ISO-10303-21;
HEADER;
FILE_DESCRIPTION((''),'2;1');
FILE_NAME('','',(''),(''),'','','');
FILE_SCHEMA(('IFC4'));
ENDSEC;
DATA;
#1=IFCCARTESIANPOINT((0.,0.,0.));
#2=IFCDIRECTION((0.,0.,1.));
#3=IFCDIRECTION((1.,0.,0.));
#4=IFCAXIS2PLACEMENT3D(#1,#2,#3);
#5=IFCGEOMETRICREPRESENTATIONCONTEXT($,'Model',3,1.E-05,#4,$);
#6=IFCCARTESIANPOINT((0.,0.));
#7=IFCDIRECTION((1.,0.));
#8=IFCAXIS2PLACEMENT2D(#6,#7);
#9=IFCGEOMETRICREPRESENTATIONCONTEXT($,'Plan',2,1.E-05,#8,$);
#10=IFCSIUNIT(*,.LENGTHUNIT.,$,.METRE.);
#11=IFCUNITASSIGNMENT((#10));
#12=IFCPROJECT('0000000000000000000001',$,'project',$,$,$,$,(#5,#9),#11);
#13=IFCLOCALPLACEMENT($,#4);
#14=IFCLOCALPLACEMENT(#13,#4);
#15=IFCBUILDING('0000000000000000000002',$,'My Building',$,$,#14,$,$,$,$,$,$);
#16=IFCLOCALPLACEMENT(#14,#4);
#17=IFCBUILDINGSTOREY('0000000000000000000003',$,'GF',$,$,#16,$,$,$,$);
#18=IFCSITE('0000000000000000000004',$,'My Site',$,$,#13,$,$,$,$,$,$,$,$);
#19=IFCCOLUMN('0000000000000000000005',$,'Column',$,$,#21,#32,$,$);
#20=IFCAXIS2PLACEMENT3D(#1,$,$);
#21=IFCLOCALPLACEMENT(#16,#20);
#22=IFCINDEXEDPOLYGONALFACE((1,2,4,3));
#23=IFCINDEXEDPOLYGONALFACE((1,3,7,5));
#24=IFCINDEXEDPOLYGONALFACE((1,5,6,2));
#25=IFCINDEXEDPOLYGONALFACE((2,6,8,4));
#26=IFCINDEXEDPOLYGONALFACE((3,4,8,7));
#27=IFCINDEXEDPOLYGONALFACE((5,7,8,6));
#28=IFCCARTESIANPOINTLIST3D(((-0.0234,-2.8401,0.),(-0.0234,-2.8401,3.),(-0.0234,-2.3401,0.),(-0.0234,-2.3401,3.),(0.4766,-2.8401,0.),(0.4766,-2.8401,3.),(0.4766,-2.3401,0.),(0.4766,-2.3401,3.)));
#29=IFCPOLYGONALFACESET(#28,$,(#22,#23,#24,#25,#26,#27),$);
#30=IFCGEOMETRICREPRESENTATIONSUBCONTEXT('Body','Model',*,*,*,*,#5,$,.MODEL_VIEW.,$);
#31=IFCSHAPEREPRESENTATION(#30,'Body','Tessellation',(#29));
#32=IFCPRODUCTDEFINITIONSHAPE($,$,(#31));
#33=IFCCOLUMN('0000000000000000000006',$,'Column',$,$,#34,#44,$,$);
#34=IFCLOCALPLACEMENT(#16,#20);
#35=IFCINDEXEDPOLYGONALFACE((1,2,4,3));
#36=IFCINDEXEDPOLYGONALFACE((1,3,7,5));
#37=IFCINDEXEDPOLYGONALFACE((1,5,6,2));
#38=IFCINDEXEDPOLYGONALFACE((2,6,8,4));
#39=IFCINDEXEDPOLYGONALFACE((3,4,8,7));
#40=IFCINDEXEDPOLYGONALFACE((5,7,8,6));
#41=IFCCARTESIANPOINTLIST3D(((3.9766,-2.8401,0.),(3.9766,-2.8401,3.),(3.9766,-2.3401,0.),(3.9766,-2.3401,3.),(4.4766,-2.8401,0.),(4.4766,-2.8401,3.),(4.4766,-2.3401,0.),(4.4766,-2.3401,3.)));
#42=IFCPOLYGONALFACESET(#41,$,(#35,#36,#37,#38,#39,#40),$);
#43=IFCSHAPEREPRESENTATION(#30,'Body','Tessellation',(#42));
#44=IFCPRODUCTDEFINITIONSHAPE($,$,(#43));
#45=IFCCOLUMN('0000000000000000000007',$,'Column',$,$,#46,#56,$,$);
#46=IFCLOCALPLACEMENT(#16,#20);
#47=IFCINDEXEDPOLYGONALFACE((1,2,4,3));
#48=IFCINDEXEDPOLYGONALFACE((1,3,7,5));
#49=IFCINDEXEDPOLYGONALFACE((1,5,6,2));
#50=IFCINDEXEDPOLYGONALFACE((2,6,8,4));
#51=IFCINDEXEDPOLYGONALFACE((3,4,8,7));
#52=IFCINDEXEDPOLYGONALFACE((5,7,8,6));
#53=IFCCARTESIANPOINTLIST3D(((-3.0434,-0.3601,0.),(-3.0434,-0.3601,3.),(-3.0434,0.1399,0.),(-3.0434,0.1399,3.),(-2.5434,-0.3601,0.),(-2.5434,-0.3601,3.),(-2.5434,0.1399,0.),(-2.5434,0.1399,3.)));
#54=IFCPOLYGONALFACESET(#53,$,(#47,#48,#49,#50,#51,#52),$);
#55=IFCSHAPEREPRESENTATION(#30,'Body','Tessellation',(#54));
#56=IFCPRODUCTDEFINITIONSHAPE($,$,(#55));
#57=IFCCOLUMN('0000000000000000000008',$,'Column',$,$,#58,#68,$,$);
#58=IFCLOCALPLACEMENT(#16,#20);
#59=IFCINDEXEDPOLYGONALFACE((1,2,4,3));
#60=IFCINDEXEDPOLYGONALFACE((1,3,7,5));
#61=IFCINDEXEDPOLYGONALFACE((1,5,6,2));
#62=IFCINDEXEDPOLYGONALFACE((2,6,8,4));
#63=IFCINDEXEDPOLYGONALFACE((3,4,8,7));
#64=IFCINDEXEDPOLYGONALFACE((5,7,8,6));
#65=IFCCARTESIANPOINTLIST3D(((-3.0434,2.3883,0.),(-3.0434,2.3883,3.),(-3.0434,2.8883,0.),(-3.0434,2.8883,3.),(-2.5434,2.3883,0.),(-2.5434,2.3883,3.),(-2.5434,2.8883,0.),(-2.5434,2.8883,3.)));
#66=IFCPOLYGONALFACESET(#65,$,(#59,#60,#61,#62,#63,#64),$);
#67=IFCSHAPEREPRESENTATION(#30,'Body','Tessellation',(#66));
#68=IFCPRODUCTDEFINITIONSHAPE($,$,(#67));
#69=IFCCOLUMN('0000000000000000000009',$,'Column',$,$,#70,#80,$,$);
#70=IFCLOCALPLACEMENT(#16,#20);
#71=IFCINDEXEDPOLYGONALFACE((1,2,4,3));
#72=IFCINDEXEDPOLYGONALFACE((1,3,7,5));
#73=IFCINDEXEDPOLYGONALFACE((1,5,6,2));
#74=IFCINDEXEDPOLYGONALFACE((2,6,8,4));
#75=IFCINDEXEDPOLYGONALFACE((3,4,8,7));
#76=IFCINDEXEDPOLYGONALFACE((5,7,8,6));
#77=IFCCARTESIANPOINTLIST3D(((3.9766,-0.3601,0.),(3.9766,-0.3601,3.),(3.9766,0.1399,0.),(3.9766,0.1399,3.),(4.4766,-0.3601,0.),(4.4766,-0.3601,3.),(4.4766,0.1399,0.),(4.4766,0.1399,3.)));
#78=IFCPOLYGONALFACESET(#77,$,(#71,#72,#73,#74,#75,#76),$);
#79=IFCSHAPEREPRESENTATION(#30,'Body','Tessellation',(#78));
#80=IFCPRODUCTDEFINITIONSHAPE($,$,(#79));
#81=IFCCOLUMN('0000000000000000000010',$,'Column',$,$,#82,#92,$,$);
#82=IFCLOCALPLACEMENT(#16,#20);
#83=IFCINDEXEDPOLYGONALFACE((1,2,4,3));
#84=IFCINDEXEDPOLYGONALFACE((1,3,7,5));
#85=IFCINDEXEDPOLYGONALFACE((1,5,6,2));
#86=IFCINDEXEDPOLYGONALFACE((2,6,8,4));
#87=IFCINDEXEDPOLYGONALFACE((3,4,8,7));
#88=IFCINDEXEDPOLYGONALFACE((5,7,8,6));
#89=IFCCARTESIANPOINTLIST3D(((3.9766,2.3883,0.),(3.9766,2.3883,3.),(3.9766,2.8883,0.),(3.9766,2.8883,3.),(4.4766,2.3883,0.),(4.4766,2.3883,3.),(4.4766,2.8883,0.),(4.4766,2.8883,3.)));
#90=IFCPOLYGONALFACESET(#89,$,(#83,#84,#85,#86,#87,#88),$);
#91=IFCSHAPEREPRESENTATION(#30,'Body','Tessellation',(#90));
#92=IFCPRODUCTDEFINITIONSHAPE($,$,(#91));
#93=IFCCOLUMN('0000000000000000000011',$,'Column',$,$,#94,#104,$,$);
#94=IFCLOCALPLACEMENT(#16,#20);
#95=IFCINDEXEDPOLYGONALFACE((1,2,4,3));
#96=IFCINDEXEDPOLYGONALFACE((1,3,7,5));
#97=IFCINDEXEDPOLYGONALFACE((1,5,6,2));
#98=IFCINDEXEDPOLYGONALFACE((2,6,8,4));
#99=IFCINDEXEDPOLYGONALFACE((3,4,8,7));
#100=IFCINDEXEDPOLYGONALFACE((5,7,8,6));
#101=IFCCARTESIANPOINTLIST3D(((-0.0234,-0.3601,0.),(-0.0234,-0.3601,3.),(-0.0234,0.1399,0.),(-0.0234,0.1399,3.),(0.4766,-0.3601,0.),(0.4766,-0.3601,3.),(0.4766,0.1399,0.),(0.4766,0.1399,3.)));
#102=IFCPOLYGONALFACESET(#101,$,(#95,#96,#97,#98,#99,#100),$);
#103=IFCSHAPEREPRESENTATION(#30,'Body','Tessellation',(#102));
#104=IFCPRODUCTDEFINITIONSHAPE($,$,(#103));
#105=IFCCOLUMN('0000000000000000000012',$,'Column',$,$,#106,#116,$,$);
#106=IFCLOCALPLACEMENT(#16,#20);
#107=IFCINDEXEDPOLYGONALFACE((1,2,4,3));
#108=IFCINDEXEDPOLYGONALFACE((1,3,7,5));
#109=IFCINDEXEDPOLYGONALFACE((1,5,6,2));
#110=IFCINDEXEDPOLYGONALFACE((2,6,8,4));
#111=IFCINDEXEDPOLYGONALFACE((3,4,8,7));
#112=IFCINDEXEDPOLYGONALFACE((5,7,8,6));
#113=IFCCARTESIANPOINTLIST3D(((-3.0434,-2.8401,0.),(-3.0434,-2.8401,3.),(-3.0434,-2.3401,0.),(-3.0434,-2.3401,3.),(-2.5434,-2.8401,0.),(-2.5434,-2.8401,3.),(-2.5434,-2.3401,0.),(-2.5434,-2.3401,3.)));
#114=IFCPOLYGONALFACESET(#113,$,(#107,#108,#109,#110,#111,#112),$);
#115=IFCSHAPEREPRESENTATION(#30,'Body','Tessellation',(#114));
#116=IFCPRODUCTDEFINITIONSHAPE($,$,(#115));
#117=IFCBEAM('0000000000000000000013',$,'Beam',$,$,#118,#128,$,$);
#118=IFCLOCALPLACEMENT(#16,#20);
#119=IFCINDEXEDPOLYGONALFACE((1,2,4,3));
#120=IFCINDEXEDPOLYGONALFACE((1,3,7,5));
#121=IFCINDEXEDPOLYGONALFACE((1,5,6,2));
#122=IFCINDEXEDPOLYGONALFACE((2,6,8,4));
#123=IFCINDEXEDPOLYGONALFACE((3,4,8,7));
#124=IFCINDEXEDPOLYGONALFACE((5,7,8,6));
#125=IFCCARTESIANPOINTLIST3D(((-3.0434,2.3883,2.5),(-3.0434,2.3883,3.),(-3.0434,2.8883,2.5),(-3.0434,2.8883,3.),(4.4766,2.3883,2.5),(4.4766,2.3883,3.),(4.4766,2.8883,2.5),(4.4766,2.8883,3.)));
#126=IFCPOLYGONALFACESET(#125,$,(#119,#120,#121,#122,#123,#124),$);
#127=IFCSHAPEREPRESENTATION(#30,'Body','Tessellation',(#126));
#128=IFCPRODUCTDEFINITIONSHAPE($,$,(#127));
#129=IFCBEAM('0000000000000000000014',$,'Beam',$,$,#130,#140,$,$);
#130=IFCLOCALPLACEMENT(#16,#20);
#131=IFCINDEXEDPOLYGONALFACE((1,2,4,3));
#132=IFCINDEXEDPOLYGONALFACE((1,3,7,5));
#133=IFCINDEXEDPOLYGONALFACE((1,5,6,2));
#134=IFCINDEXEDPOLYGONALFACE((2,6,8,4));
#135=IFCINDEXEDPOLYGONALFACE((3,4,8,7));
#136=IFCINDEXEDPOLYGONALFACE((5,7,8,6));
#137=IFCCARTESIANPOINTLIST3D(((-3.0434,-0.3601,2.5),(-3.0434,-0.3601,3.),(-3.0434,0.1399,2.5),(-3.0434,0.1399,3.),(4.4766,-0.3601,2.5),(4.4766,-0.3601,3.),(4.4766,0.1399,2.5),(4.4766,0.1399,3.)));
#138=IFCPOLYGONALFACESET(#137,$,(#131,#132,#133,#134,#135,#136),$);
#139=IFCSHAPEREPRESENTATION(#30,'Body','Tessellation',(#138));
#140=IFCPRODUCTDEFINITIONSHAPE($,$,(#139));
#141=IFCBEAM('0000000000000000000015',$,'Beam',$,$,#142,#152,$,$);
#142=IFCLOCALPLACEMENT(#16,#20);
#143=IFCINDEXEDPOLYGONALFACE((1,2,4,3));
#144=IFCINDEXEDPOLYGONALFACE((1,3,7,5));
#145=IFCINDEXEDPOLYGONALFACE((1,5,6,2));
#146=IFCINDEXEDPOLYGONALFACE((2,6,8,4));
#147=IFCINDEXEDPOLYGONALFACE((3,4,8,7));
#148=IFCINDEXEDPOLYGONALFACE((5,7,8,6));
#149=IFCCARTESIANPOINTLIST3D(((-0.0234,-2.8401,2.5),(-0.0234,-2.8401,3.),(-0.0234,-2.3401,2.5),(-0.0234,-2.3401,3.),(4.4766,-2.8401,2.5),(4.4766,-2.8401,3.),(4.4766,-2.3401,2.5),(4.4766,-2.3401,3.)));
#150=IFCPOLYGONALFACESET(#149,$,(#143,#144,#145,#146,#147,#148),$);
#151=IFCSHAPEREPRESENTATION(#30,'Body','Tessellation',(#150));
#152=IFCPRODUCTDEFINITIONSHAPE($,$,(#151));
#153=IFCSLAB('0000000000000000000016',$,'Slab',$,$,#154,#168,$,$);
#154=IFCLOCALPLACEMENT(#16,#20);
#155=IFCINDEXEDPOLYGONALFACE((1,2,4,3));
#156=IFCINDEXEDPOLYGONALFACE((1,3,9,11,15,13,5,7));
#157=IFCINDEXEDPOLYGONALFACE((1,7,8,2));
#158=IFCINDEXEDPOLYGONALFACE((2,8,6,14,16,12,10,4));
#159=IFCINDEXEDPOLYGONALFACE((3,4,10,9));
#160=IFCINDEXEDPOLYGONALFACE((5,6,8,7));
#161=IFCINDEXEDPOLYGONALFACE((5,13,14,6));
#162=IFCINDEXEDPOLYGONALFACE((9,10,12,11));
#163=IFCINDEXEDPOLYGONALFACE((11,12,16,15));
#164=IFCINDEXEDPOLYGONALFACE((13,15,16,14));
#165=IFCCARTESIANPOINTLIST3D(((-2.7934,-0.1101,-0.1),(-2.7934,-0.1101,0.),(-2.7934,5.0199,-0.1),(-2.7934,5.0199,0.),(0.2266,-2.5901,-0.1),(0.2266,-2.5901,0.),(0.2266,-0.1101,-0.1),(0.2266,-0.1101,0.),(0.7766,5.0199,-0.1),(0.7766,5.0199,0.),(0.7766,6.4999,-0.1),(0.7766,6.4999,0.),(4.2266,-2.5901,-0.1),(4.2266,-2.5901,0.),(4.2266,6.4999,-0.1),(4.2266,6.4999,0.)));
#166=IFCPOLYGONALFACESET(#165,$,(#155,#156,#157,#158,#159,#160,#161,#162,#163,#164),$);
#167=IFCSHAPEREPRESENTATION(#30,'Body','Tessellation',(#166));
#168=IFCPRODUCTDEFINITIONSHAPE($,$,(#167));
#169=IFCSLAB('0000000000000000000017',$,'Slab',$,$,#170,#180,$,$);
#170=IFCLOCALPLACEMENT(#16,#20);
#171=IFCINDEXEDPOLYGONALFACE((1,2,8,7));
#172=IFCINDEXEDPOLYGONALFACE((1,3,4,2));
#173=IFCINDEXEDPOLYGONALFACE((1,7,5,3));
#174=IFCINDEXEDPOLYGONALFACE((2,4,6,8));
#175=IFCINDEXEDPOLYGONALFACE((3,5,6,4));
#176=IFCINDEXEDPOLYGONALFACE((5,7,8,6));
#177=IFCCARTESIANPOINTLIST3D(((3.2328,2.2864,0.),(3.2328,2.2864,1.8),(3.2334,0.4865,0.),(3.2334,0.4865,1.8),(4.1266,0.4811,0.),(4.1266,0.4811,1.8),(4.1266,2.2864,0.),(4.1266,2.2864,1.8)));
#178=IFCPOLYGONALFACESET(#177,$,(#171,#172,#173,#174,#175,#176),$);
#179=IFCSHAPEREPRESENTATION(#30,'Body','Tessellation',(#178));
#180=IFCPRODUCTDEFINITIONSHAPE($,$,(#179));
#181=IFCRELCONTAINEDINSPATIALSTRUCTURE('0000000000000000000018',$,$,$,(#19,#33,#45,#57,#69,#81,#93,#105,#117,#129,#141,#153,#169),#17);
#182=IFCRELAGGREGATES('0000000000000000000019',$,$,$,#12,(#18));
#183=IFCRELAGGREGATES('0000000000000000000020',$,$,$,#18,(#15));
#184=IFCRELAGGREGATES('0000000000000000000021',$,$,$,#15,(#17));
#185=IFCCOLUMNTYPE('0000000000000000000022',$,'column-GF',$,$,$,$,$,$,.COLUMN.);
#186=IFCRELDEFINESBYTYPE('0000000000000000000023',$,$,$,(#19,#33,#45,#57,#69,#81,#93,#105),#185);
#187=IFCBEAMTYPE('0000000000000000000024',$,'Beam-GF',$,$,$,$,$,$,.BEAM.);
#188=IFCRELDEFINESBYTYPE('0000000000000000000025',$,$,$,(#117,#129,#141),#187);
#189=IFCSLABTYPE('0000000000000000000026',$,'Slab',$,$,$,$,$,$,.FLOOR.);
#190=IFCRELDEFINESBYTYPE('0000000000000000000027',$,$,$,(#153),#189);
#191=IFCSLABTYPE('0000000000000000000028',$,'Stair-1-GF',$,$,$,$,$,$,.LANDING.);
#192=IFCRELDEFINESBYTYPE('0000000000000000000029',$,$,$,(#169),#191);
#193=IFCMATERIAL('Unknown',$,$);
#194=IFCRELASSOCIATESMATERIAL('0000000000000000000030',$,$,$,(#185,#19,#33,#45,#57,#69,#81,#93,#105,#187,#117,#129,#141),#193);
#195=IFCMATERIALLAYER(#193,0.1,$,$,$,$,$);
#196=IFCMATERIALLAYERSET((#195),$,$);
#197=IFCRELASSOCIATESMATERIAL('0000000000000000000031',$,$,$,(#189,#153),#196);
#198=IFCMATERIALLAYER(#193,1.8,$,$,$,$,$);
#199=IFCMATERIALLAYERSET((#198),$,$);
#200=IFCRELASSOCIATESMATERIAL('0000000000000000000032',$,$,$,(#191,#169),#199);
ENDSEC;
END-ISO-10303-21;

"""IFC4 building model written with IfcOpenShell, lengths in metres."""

from ifc_helpers import new_model, si_unit, frame, origin_with_axes, origin_2d_with_axis, place, context, subcontext, project, spatial, indexed_curve, rectangle, outline, extrude, material, layer, layer_set, layer_usage, material_profile, profile_set, profile_usage, type_object, element, save


model = new_model("IFC4")

# Units and contexts
model_context = context("Model", 3, precision=1e-05, world=origin_with_axes())
plan_context = context("Plan", 2, precision=1e-05, world=origin_2d_with_axis())
body_context_1 = subcontext(model_context, "Body", "Model", "MODEL_VIEW")
ifc_project = project(units=[si_unit("LENGTHUNIT", "METRE")], contexts=[model_context, plan_context])

# Site, building, storey
site_placement = place(None, origin_with_axes())
site = spatial("IfcSite", under=ifc_project, at=site_placement, Name="My Site")
building_placement = place(site_placement, origin_with_axes())
building = spatial("IfcBuilding", under=site, at=building_placement, Name="My Building")
storey_placement = place(building_placement, origin_with_axes())
storey = spatial("IfcBuildingStorey", under=building, at=storey_placement, Name="GF")

# Columns
ifc_material = material(Name="Unknown")
ifc_material_profile_1 = material_profile(ifc_material, rectangle(XDim=0.5, YDim=0.5))
ifc_profile_set_1 = profile_set([ifc_material_profile_1])
ifc_profile_usage_1 = profile_usage(ifc_profile_set_1, cardinal=5)
column_type = type_object("IfcColumnType", Name="column-GF", PredefinedType="COLUMN", material=ifc_profile_set_1)
column_1_placement = place(storey_placement, frame((0.2266, -2.5901, 0.0), z_axis=(0.0, 0.0, 1.0), x_axis=(1.0, 0.0, 0.0)))
element("IfcColumn", 1, at=column_1_placement, inside=storey, type_object=column_type, material=ifc_profile_usage_1, Name="Column", context=body_context_1, shape_type="SweptSolid", body=[
    extrude(rectangle(XDim=0.5, YDim=0.5), origin_with_axes(), (0.0, 0.0, 1.0), 3.0),
])
ifc_profile_usage_2 = profile_usage(ifc_profile_set_1, cardinal=5)
column_2_placement = place(storey_placement, frame((4.2266, -2.5901, 0.0), z_axis=(0.0, 0.0, 1.0), x_axis=(1.0, 0.0, 0.0)))
element("IfcColumn", 2, at=column_2_placement, inside=storey, type_object=column_type, material=ifc_profile_usage_2, Name="Column", context=body_context_1, shape_type="SweptSolid", body=[
    extrude(rectangle(XDim=0.5, YDim=0.5), origin_with_axes(), (0.0, 0.0, 1.0), 3.0),
])
ifc_profile_usage_3 = profile_usage(ifc_profile_set_1, cardinal=5)
column_3_placement = place(storey_placement, frame((-2.7934, -0.1101, 0.0), z_axis=(0.0, 0.0, 1.0), x_axis=(1.0, 0.0, 0.0)))
element("IfcColumn", 3, at=column_3_placement, inside=storey, type_object=column_type, material=ifc_profile_usage_3, Name="Column", context=body_context_1, shape_type="SweptSolid", body=[
    extrude(rectangle(XDim=0.5, YDim=0.5), origin_with_axes(), (0.0, 0.0, 1.0), 3.0),
])
ifc_profile_usage_4 = profile_usage(ifc_profile_set_1, cardinal=5)
column_4_placement = place(storey_placement, frame((-2.7934, 2.6383, 0.0), z_axis=(0.0, 0.0, 1.0), x_axis=(1.0, 0.0, 0.0)))
element("IfcColumn", 4, at=column_4_placement, inside=storey, type_object=column_type, material=ifc_profile_usage_4, Name="Column", context=body_context_1, shape_type="SweptSolid", body=[
    extrude(rectangle(XDim=0.5, YDim=0.5), origin_with_axes(), (0.0, 0.0, 1.0), 3.0),
])
ifc_profile_usage_5 = profile_usage(ifc_profile_set_1, cardinal=5)
column_5_placement = place(storey_placement, frame((4.2266, -0.1101, 0.0), z_axis=(0.0, 0.0, 1.0), x_axis=(1.0, 0.0, 0.0)))
element("IfcColumn", 5, at=column_5_placement, inside=storey, type_object=column_type, material=ifc_profile_usage_5, Name="Column", context=body_context_1, shape_type="SweptSolid", body=[
    extrude(rectangle(XDim=0.5, YDim=0.5), origin_with_axes(), (0.0, 0.0, 1.0), 3.0),
])
ifc_profile_usage_6 = profile_usage(ifc_profile_set_1, cardinal=5)
column_6_placement = place(storey_placement, frame((4.2266, 2.6383, 0.0), z_axis=(0.0, 0.0, 1.0), x_axis=(1.0, 0.0, 0.0)))
element("IfcColumn", 6, at=column_6_placement, inside=storey, type_object=column_type, material=ifc_profile_usage_6, Name="Column", context=body_context_1, shape_type="SweptSolid", body=[
    extrude(rectangle(XDim=0.5, YDim=0.5), origin_with_axes(), (0.0, 0.0, 1.0), 3.0),
])
ifc_profile_usage_7 = profile_usage(ifc_profile_set_1, cardinal=5)
column_7_placement = place(storey_placement, frame((0.2266, -0.1101, 0.0), z_axis=(0.0, 0.0, 1.0), x_axis=(1.0, 0.0, 0.0)))
element("IfcColumn", 7, at=column_7_placement, inside=storey, type_object=column_type, material=ifc_profile_usage_7, Name="Column", context=body_context_1, shape_type="SweptSolid", body=[
    extrude(rectangle(XDim=0.5, YDim=0.5), origin_with_axes(), (0.0, 0.0, 1.0), 3.0),
])
ifc_profile_usage_8 = profile_usage(ifc_profile_set_1, cardinal=5)
column_8_placement = place(storey_placement, frame((-2.7934, -2.5901, 0.0), z_axis=(0.0, 0.0, 1.0), x_axis=(1.0, 0.0, 0.0)))
element("IfcColumn", 8, at=column_8_placement, inside=storey, type_object=column_type, material=ifc_profile_usage_8, Name="Column", context=body_context_1, shape_type="SweptSolid", body=[
    extrude(rectangle(XDim=0.5, YDim=0.5), origin_with_axes(), (0.0, 0.0, 1.0), 3.0),
])

# Beams
ifc_material_profile_2 = material_profile(ifc_material, rectangle(XDim=0.5, YDim=0.5))
ifc_profile_set_2 = profile_set([ifc_material_profile_2])
ifc_profile_usage_9 = profile_usage(ifc_profile_set_2, cardinal=7)
beam_type = type_object("IfcBeamType", Name="Beam-GF", PredefinedType="BEAM", material=ifc_profile_set_2)
beam_1_placement = place(storey_placement, frame((4.4766, 2.3883, 3.0), z_axis=(-1.0, 0.0, 0.0), x_axis=(0.0, -1.0, 0.0)))
element("IfcBeam", 9, at=beam_1_placement, inside=storey, type_object=beam_type, material=ifc_profile_usage_9, Name="Beam", context=body_context_1, shape_type="SweptSolid", body=[
    extrude(rectangle(XDim=0.5, YDim=0.5), frame((-0.25, -0.25, 0.0), z_axis=(0.0, 0.0, 1.0), x_axis=(1.0, 0.0, 0.0)), (0.0, 0.0, 1.0), 7.52),
])
ifc_profile_usage_10 = profile_usage(ifc_profile_set_2, cardinal=7)
beam_2_placement = place(storey_placement, frame((4.4766, -0.3601, 3.0), z_axis=(-1.0, 0.0, 0.0), x_axis=(0.0, -1.0, 0.0)))
element("IfcBeam", 10, at=beam_2_placement, inside=storey, type_object=beam_type, material=ifc_profile_usage_10, Name="Beam", context=body_context_1, shape_type="SweptSolid", body=[
    extrude(rectangle(XDim=0.5, YDim=0.5), frame((-0.25, -0.25, 0.0), z_axis=(0.0, 0.0, 1.0), x_axis=(1.0, 0.0, 0.0)), (0.0, 0.0, 1.0), 7.52),
])
ifc_profile_usage_11 = profile_usage(ifc_profile_set_2, cardinal=7)
beam_3_placement = place(storey_placement, frame((4.4766, -2.8401, 3.0), z_axis=(-1.0, -0.000001, 0.000001), x_axis=(0.000001, -1.0, 0.0)))
element("IfcBeam", 11, at=beam_3_placement, inside=storey, type_object=beam_type, material=ifc_profile_usage_11, Name="Beam", context=body_context_1, shape_type="SweptSolid", body=[
    extrude(rectangle(XDim=0.5, YDim=0.5), frame((-0.25, -0.25, 0.0), z_axis=(0.0, 0.0, 1.0), x_axis=(1.0, 0.0, 0.0)), (0.0, 0.0, 1.0), 4.5),
])

# Slabs
ifc_layer_1 = layer(ifc_material, 0.1)
ifc_layer_set_1 = layer_set([ifc_layer_1])
ifc_layer_usage_1 = layer_usage(ifc_layer_set_1, "AXIS3", "POSITIVE", -0.1)
slab_type_1 = type_object("IfcSlabType", Name="Slab", PredefinedType="FLOOR", material=ifc_layer_set_1)
slab_1_placement = place(storey_placement, frame((4.2266, -2.5901, 0.0), z_axis=(0.0, 0.0, 1.0), x_axis=(1.0, 0.0, 0.0)))
element("IfcSlab", 12, at=slab_1_placement, inside=storey, type_object=slab_type_1, material=ifc_layer_usage_1, Name="Slab", context=body_context_1, shape_type="SweptSolid", body=[
    extrude(outline(indexed_curve([(0.0, 0.0), (0.0, 9.09), (-3.45, 9.09), (-3.45, 7.61), (-7.02, 7.61), (-7.02, 2.48), (-4.0, 2.48), (-4.0, 0.0), (0.0, 0.0)])), frame((0.0, 0.0, -0.1), z_axis=(0.0, 0.0, 1.0), x_axis=(1.0, 0.0, 0.0)), (0.0, 0.0, 1.0), 0.1),
])
ifc_layer_2 = layer(ifc_material, 1.8)
ifc_layer_set_2 = layer_set([ifc_layer_2])
ifc_layer_usage_2 = layer_usage(ifc_layer_set_2, "AXIS3", "POSITIVE", -0.1)
slab_type_2 = type_object("IfcSlabType", Name="Stair-1-GF", PredefinedType="LANDING", material=ifc_layer_set_2)
slab_2_placement = place(storey_placement, frame((3.2334, 0.4865, 0.1), z_axis=(0.0, 0.0, 1.0), x_axis=(1.0, 0.0, 0.0)))
element("IfcSlab", 13, at=slab_2_placement, inside=storey, type_object=slab_type_2, material=ifc_layer_usage_2, Name="Slab", context=body_context_1, shape_type="SweptSolid", body=[
    extrude(outline(indexed_curve([(-0.0006, 1.7999), (0.8932, 1.7999), (0.8932, -0.0054), (0.0, 0.0), (-0.0006, 1.7999)])), frame((0.0, 0.0, -0.1), z_axis=(0.0, 0.0, 1.0), x_axis=(1.0, 0.0, 0.0)), (0.0, 0.0, 1.0), 1.8),
])

save(model, "model.ifc")
